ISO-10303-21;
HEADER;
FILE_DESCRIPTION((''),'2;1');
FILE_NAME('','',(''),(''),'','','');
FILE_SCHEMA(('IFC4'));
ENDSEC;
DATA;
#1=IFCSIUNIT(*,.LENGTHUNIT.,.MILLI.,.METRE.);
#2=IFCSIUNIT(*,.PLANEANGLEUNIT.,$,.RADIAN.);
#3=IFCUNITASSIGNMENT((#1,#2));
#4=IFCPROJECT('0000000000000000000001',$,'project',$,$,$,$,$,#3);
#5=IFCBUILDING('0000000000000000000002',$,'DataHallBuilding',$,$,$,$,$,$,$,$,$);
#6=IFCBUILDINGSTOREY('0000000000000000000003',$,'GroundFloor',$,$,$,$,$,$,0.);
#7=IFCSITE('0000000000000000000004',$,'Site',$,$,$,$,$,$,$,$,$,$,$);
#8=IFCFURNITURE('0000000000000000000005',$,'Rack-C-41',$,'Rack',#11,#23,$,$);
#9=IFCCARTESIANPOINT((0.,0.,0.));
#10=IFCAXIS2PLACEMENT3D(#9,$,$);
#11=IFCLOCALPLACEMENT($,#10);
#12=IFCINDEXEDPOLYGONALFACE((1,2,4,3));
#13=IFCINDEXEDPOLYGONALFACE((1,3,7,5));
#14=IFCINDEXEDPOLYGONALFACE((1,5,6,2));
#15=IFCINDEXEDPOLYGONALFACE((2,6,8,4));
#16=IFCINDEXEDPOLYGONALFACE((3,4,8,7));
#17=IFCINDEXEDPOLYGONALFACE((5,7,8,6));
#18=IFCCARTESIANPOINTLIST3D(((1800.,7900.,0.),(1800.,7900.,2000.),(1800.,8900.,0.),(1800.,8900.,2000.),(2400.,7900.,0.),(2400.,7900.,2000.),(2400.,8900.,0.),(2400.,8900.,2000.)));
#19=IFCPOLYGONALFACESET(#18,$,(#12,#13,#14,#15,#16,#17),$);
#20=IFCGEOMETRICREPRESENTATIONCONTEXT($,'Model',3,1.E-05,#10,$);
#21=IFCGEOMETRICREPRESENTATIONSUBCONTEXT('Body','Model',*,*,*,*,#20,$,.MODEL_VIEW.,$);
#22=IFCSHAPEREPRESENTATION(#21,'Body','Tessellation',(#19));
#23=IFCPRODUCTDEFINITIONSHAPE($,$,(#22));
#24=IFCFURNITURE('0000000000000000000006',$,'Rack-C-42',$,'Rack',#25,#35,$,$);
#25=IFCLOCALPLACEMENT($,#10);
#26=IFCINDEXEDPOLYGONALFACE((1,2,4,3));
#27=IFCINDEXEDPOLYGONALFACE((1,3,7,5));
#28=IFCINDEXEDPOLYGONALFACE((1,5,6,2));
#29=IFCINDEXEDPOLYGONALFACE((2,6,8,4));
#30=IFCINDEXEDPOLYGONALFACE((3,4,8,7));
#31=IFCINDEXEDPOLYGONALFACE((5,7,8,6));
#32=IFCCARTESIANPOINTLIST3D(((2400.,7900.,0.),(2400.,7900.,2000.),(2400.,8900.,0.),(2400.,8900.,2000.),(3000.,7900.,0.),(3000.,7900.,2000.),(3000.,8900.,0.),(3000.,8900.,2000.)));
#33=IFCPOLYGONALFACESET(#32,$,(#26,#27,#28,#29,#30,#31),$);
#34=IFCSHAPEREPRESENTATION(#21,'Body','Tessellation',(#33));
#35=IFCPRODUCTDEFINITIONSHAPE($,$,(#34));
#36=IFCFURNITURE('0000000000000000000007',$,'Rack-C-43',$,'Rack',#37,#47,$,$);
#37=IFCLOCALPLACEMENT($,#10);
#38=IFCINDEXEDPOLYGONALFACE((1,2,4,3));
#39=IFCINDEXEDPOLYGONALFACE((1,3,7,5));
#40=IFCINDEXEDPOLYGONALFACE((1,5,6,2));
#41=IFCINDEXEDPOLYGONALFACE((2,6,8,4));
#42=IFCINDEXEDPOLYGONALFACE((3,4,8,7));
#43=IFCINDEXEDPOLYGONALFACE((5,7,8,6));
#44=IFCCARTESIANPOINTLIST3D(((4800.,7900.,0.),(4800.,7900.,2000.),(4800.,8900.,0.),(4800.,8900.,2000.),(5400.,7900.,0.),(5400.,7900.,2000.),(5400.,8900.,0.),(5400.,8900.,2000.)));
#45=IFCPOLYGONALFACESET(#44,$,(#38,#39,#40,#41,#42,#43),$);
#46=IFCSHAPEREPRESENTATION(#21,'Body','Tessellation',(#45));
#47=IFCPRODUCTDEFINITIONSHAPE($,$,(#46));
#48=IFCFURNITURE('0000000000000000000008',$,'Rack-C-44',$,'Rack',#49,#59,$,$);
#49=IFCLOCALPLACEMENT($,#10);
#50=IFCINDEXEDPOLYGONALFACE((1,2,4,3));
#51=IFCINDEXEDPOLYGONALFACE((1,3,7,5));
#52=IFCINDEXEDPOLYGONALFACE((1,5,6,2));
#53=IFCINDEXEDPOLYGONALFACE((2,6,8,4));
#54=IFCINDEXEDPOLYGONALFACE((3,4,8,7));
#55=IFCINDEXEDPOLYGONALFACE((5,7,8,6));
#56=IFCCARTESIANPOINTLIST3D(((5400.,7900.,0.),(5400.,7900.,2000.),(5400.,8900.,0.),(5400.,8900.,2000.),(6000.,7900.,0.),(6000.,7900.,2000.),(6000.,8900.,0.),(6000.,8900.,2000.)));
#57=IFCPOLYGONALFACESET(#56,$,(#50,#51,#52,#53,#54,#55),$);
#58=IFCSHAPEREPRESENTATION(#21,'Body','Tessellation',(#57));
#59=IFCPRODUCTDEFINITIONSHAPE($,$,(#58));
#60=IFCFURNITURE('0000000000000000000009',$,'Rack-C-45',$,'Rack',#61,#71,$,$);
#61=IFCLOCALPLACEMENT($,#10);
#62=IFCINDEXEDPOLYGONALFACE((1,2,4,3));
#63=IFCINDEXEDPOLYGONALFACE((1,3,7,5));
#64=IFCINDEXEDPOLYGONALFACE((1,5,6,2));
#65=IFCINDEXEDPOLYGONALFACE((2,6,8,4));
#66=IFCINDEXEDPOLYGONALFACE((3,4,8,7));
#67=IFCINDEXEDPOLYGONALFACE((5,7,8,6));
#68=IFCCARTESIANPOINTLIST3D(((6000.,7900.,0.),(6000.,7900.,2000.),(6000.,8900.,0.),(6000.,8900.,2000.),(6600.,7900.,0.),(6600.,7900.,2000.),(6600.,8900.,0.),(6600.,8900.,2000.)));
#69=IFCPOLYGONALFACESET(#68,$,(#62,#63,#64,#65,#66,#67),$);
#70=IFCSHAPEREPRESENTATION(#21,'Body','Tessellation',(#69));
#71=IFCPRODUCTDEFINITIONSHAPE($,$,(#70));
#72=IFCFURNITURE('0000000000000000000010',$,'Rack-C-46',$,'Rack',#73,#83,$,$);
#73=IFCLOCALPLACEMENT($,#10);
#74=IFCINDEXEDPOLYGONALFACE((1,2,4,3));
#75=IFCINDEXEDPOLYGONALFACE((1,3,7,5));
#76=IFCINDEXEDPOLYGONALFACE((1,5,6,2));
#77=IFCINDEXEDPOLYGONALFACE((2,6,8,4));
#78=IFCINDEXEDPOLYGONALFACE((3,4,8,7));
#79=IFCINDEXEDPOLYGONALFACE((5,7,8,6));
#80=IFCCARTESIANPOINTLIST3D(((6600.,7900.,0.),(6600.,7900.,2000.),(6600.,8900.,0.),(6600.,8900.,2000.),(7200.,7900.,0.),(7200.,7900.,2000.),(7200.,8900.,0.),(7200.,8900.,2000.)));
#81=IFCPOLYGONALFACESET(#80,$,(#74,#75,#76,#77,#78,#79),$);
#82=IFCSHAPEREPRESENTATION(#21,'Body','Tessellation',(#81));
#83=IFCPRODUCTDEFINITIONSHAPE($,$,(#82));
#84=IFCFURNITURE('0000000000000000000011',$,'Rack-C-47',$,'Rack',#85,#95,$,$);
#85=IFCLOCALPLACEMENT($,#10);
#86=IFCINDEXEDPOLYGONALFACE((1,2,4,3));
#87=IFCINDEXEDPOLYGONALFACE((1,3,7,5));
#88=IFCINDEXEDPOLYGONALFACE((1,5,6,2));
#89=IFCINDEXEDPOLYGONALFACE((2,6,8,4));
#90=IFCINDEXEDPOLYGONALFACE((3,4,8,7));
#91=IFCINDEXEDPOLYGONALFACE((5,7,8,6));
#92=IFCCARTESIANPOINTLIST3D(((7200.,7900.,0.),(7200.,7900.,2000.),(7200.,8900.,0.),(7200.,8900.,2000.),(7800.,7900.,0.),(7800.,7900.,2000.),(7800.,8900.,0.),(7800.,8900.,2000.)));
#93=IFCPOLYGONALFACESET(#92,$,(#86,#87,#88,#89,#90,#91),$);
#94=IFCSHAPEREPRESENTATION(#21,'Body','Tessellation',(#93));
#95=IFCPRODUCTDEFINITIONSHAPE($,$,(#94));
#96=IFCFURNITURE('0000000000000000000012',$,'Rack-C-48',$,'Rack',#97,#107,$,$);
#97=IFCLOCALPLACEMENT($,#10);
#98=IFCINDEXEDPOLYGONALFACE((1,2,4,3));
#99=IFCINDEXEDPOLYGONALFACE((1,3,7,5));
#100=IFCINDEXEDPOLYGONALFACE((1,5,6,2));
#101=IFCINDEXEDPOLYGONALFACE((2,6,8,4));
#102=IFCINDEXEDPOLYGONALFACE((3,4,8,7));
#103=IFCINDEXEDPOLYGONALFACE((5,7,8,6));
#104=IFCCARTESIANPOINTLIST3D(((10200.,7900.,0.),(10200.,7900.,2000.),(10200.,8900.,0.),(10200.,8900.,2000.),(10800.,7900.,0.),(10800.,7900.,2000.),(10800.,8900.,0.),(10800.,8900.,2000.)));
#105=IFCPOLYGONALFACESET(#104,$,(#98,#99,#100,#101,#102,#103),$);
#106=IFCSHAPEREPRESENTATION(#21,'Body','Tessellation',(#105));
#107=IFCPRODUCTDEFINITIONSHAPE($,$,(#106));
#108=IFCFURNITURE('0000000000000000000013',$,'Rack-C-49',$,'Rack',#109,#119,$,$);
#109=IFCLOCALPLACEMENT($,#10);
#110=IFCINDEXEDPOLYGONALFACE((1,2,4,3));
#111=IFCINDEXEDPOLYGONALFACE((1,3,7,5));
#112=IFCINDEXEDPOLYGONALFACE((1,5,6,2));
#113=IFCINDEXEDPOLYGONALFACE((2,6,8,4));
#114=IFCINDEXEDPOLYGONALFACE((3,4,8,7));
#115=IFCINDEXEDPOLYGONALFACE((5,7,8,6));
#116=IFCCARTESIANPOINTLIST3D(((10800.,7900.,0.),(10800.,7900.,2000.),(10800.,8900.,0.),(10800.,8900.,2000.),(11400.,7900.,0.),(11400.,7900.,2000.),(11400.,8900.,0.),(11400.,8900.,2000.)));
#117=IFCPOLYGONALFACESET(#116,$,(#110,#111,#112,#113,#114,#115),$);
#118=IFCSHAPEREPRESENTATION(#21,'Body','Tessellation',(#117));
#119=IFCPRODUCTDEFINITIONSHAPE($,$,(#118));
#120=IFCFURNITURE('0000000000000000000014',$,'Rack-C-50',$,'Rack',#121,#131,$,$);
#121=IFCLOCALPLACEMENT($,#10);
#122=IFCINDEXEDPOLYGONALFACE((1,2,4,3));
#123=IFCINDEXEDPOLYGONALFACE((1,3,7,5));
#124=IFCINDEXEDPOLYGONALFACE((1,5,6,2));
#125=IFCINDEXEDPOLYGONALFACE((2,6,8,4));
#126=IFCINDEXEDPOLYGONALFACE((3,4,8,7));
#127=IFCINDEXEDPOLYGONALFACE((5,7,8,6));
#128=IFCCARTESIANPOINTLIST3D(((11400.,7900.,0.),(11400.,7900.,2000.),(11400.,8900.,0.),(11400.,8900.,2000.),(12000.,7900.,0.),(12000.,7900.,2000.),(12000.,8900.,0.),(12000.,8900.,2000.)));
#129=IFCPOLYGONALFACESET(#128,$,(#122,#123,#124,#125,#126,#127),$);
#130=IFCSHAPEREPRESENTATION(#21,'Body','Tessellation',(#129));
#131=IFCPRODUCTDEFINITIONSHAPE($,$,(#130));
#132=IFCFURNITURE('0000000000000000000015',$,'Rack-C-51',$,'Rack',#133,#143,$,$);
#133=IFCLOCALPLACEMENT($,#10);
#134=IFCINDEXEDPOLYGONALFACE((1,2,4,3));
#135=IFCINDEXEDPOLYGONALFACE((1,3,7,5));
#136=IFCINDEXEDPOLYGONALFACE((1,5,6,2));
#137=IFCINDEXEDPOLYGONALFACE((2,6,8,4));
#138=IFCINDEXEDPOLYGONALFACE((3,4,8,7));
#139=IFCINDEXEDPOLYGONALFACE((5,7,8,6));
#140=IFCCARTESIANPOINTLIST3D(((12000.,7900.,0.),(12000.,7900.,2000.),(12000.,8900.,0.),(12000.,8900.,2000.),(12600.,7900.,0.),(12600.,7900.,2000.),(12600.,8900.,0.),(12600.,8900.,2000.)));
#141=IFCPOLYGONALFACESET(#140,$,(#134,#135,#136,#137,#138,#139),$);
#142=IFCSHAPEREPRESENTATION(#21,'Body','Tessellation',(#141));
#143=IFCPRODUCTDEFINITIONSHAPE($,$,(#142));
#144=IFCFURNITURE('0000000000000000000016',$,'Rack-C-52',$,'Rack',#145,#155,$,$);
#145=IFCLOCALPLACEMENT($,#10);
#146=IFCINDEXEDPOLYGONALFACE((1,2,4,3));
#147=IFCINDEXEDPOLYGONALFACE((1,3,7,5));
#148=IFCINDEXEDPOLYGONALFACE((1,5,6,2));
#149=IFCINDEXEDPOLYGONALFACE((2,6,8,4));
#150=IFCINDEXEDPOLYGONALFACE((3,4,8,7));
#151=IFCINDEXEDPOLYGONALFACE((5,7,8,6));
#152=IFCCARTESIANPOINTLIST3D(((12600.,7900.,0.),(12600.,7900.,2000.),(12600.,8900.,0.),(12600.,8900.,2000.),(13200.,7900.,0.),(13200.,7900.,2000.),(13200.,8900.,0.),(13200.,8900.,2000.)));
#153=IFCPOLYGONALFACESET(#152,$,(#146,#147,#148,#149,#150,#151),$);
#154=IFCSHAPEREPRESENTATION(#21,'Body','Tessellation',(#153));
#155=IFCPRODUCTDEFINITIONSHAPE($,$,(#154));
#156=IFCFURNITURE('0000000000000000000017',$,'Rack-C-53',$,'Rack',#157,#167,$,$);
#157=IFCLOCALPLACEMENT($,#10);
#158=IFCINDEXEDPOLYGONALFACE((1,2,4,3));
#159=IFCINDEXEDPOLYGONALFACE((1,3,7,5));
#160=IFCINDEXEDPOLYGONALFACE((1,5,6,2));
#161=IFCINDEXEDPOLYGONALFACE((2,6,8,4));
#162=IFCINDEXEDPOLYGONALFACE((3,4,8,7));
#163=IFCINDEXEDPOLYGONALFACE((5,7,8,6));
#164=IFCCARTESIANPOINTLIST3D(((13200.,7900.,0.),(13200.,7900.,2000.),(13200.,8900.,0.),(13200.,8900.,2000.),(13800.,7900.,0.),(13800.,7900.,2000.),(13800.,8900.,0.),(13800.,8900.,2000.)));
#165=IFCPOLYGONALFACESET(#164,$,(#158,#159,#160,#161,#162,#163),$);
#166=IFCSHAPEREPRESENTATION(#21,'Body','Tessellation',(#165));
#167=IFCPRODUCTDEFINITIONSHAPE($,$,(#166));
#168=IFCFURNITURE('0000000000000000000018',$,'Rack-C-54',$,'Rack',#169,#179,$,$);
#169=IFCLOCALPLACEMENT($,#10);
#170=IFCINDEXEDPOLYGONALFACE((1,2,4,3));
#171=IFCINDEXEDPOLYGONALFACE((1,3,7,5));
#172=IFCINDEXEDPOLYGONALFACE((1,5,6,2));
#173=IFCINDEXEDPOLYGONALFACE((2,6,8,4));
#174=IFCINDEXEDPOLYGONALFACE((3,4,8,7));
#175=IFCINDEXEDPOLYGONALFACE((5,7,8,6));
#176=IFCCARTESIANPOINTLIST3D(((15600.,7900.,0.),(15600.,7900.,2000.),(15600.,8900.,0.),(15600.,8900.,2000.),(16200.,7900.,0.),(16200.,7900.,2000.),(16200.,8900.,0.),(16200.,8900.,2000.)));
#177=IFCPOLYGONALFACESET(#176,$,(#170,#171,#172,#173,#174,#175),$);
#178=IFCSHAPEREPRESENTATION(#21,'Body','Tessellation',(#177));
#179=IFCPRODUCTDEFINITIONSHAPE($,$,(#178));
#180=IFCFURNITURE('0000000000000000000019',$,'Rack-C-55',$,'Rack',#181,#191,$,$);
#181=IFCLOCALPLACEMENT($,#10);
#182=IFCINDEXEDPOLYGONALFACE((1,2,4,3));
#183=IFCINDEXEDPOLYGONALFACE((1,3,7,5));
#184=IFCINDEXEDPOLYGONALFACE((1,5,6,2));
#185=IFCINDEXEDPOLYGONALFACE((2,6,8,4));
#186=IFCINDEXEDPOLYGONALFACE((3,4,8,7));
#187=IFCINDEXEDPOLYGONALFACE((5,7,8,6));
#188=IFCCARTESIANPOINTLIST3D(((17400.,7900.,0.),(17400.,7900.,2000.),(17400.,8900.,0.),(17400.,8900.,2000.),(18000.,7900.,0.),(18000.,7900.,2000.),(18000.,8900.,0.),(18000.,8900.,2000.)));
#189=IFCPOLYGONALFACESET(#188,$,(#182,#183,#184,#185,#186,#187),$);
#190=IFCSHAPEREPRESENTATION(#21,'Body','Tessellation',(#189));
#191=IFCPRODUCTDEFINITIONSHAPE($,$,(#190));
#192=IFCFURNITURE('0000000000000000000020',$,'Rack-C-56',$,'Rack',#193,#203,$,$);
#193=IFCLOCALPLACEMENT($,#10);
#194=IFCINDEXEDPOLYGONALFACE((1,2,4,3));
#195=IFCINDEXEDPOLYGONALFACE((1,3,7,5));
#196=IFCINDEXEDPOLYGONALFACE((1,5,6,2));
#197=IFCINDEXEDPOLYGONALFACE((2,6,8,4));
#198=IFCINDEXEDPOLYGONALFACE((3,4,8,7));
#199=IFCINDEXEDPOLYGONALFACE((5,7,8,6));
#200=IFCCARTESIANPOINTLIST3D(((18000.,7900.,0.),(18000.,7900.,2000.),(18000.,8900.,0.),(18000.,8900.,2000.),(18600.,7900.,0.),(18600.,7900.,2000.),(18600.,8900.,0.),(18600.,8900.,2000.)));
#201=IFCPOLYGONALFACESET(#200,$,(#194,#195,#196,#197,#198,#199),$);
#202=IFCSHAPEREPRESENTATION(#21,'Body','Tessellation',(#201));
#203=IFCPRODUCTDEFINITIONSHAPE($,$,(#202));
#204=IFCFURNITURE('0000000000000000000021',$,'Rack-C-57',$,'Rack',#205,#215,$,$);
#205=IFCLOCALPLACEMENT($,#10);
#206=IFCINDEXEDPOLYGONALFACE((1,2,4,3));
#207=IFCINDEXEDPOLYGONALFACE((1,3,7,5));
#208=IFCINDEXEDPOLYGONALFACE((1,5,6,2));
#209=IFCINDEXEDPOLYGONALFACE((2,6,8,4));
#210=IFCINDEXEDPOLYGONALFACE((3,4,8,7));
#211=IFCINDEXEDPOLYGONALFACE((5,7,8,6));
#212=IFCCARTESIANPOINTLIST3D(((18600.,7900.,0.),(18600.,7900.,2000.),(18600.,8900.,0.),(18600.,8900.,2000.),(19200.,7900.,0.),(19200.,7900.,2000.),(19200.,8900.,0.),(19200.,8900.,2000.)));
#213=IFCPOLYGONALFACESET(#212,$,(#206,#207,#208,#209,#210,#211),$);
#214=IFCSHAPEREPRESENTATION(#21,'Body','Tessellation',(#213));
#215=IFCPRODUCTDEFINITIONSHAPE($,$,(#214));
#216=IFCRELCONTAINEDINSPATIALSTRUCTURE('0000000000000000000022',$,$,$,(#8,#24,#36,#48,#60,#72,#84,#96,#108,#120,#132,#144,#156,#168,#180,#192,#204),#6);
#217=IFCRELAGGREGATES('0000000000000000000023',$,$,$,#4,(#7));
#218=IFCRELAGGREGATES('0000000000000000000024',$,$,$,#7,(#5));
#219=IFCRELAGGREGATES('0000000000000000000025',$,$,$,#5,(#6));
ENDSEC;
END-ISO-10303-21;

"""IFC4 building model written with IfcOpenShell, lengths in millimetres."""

from ifc_helpers import new_model, si_unit, frame, origin, place, context, subcontext, project, spatial, rectangle, extrude, element, save


model = new_model("IFC4")

# Units and contexts
model_context = context("Model", 3, precision=1e-05, world=origin())
body_context = subcontext(model_context, "Body", "Model", "MODEL_VIEW")
ifc_project = project(units=[si_unit("LENGTHUNIT", "METRE", prefix="MILLI"), si_unit("PLANEANGLEUNIT", "RADIAN")])

# Site, building, storey
site = spatial("IfcSite", under=ifc_project, Name="Site")
building = spatial("IfcBuilding", under=site, Name="DataHallBuilding")
storey = spatial("IfcBuildingStorey", under=building, Name="GroundFloor", Elevation=0.0)

# Furniture
furniture_1_placement = place(None, origin())
element("IfcFurniture", 1, at=furniture_1_placement, inside=storey, Name="Rack-C-41", ObjectType="Rack", context=body_context, shape_type="SweptSolid", body=[
    extrude(rectangle(XDim=600.0, YDim=1000.0), frame((2100.0, 8400.0, 0.0), z_axis=(0.0, 0.0, 1.0), x_axis=(1.0, 0.0, 0.0)), (0.0, 0.0, 1.0), 2000.0),
])
furniture_2_placement = place(None, origin())
element("IfcFurniture", 2, at=furniture_2_placement, inside=storey, Name="Rack-C-42", ObjectType="Rack", context=body_context, shape_type="SweptSolid", body=[
    extrude(rectangle(XDim=600.0, YDim=1000.0), frame((2700.0, 8400.0, 0.0), z_axis=(0.0, 0.0, 1.0), x_axis=(1.0, 0.0, 0.0)), (0.0, 0.0, 1.0), 2000.0),
])
furniture_3_placement = place(None, origin())
element("IfcFurniture", 3, at=furniture_3_placement, inside=storey, Name="Rack-C-43", ObjectType="Rack", context=body_context, shape_type="SweptSolid", body=[
    extrude(rectangle(XDim=600.0, YDim=1000.0), frame((5100.0, 8400.0, 0.0), z_axis=(0.0, 0.0, 1.0), x_axis=(1.0, 0.0, 0.0)), (0.0, 0.0, 1.0), 2000.0),
])
furniture_4_placement = place(None, origin())
element("IfcFurniture", 4, at=furniture_4_placement, inside=storey, Name="Rack-C-44", ObjectType="Rack", context=body_context, shape_type="SweptSolid", body=[
    extrude(rectangle(XDim=600.0, YDim=1000.0), frame((5700.0, 8400.0, 0.0), z_axis=(0.0, 0.0, 1.0), x_axis=(1.0, 0.0, 0.0)), (0.0, 0.0, 1.0), 2000.0),
])
furniture_5_placement = place(None, origin())
element("IfcFurniture", 5, at=furniture_5_placement, inside=storey, Name="Rack-C-45", ObjectType="Rack", context=body_context, shape_type="SweptSolid", body=[
    extrude(rectangle(XDim=600.0, YDim=1000.0), frame((6300.0, 8400.0, 0.0), z_axis=(0.0, 0.0, 1.0), x_axis=(1.0, 0.0, 0.0)), (0.0, 0.0, 1.0), 2000.0),
])
furniture_6_placement = place(None, origin())
element("IfcFurniture", 6, at=furniture_6_placement, inside=storey, Name="Rack-C-46", ObjectType="Rack", context=body_context, shape_type="SweptSolid", body=[
    extrude(rectangle(XDim=600.0, YDim=1000.0), frame((6900.0, 8400.0, 0.0), z_axis=(0.0, 0.0, 1.0), x_axis=(1.0, 0.0, 0.0)), (0.0, 0.0, 1.0), 2000.0),
])
furniture_7_placement = place(None, origin())
element("IfcFurniture", 7, at=furniture_7_placement, inside=storey, Name="Rack-C-47", ObjectType="Rack", context=body_context, shape_type="SweptSolid", body=[
    extrude(rectangle(XDim=600.0, YDim=1000.0), frame((7500.0, 8400.0, 0.0), z_axis=(0.0, 0.0, 1.0), x_axis=(1.0, 0.0, 0.0)), (0.0, 0.0, 1.0), 2000.0),
])
furniture_8_placement = place(None, origin())
element("IfcFurniture", 8, at=furniture_8_placement, inside=storey, Name="Rack-C-48", ObjectType="Rack", context=body_context, shape_type="SweptSolid", body=[
    extrude(rectangle(XDim=600.0, YDim=1000.0), frame((10500.0, 8400.0, 0.0), z_axis=(0.0, 0.0, 1.0), x_axis=(1.0, 0.0, 0.0)), (0.0, 0.0, 1.0), 2000.0),
])
furniture_9_placement = place(None, origin())
element("IfcFurniture", 9, at=furniture_9_placement, inside=storey, Name="Rack-C-49", ObjectType="Rack", context=body_context, shape_type="SweptSolid", body=[
    extrude(rectangle(XDim=600.0, YDim=1000.0), frame((11100.0, 8400.0, 0.0), z_axis=(0.0, 0.0, 1.0), x_axis=(1.0, 0.0, 0.0)), (0.0, 0.0, 1.0), 2000.0),
])
furniture_10_placement = place(None, origin())
element("IfcFurniture", 10, at=furniture_10_placement, inside=storey, Name="Rack-C-50", ObjectType="Rack", context=body_context, shape_type="SweptSolid", body=[
    extrude(rectangle(XDim=600.0, YDim=1000.0), frame((11700.0, 8400.0, 0.0), z_axis=(0.0, 0.0, 1.0), x_axis=(1.0, 0.0, 0.0)), (0.0, 0.0, 1.0), 2000.0),
])
furniture_11_placement = place(None, origin())
element("IfcFurniture", 11, at=furniture_11_placement, inside=storey, Name="Rack-C-51", ObjectType="Rack", context=body_context, shape_type="SweptSolid", body=[
    extrude(rectangle(XDim=600.0, YDim=1000.0), frame((12300.0, 8400.0, 0.0), z_axis=(0.0, 0.0, 1.0), x_axis=(1.0, 0.0, 0.0)), (0.0, 0.0, 1.0), 2000.0),
])
furniture_12_placement = place(None, origin())
element("IfcFurniture", 12, at=furniture_12_placement, inside=storey, Name="Rack-C-52", ObjectType="Rack", context=body_context, shape_type="SweptSolid", body=[
    extrude(rectangle(XDim=600.0, YDim=1000.0), frame((12900.0, 8400.0, 0.0), z_axis=(0.0, 0.0, 1.0), x_axis=(1.0, 0.0, 0.0)), (0.0, 0.0, 1.0), 2000.0),
])
furniture_13_placement = place(None, origin())
element("IfcFurniture", 13, at=furniture_13_placement, inside=storey, Name="Rack-C-53", ObjectType="Rack", context=body_context, shape_type="SweptSolid", body=[
    extrude(rectangle(XDim=600.0, YDim=1000.0), frame((13500.0, 8400.0, 0.0), z_axis=(0.0, 0.0, 1.0), x_axis=(1.0, 0.0, 0.0)), (0.0, 0.0, 1.0), 2000.0),
])
furniture_14_placement = place(None, origin())
element("IfcFurniture", 14, at=furniture_14_placement, inside=storey, Name="Rack-C-54", ObjectType="Rack", context=body_context, shape_type="SweptSolid", body=[
    extrude(rectangle(XDim=600.0, YDim=1000.0), frame((15900.0, 8400.0, 0.0), z_axis=(0.0, 0.0, 1.0), x_axis=(1.0, 0.0, 0.0)), (0.0, 0.0, 1.0), 2000.0),
])
furniture_15_placement = place(None, origin())
element("IfcFurniture", 15, at=furniture_15_placement, inside=storey, Name="Rack-C-55", ObjectType="Rack", context=body_context, shape_type="SweptSolid", body=[
    extrude(rectangle(XDim=600.0, YDim=1000.0), frame((17700.0, 8400.0, 0.0), z_axis=(0.0, 0.0, 1.0), x_axis=(1.0, 0.0, 0.0)), (0.0, 0.0, 1.0), 2000.0),
])
furniture_16_placement = place(None, origin())
element("IfcFurniture", 16, at=furniture_16_placement, inside=storey, Name="Rack-C-56", ObjectType="Rack", context=body_context, shape_type="SweptSolid", body=[
    extrude(rectangle(XDim=600.0, YDim=1000.0), frame((18300.0, 8400.0, 0.0), z_axis=(0.0, 0.0, 1.0), x_axis=(1.0, 0.0, 0.0)), (0.0, 0.0, 1.0), 2000.0),
])
furniture_17_placement = place(None, origin())
element("IfcFurniture", 17, at=furniture_17_placement, inside=storey, Name="Rack-C-57", ObjectType="Rack", context=body_context, shape_type="SweptSolid", body=[
    extrude(rectangle(XDim=600.0, YDim=1000.0), frame((18900.0, 8400.0, 0.0), z_axis=(0.0, 0.0, 1.0), x_axis=(1.0, 0.0, 0.0)), (0.0, 0.0, 1.0), 2000.0),
])

save(model, "model.ifc")
